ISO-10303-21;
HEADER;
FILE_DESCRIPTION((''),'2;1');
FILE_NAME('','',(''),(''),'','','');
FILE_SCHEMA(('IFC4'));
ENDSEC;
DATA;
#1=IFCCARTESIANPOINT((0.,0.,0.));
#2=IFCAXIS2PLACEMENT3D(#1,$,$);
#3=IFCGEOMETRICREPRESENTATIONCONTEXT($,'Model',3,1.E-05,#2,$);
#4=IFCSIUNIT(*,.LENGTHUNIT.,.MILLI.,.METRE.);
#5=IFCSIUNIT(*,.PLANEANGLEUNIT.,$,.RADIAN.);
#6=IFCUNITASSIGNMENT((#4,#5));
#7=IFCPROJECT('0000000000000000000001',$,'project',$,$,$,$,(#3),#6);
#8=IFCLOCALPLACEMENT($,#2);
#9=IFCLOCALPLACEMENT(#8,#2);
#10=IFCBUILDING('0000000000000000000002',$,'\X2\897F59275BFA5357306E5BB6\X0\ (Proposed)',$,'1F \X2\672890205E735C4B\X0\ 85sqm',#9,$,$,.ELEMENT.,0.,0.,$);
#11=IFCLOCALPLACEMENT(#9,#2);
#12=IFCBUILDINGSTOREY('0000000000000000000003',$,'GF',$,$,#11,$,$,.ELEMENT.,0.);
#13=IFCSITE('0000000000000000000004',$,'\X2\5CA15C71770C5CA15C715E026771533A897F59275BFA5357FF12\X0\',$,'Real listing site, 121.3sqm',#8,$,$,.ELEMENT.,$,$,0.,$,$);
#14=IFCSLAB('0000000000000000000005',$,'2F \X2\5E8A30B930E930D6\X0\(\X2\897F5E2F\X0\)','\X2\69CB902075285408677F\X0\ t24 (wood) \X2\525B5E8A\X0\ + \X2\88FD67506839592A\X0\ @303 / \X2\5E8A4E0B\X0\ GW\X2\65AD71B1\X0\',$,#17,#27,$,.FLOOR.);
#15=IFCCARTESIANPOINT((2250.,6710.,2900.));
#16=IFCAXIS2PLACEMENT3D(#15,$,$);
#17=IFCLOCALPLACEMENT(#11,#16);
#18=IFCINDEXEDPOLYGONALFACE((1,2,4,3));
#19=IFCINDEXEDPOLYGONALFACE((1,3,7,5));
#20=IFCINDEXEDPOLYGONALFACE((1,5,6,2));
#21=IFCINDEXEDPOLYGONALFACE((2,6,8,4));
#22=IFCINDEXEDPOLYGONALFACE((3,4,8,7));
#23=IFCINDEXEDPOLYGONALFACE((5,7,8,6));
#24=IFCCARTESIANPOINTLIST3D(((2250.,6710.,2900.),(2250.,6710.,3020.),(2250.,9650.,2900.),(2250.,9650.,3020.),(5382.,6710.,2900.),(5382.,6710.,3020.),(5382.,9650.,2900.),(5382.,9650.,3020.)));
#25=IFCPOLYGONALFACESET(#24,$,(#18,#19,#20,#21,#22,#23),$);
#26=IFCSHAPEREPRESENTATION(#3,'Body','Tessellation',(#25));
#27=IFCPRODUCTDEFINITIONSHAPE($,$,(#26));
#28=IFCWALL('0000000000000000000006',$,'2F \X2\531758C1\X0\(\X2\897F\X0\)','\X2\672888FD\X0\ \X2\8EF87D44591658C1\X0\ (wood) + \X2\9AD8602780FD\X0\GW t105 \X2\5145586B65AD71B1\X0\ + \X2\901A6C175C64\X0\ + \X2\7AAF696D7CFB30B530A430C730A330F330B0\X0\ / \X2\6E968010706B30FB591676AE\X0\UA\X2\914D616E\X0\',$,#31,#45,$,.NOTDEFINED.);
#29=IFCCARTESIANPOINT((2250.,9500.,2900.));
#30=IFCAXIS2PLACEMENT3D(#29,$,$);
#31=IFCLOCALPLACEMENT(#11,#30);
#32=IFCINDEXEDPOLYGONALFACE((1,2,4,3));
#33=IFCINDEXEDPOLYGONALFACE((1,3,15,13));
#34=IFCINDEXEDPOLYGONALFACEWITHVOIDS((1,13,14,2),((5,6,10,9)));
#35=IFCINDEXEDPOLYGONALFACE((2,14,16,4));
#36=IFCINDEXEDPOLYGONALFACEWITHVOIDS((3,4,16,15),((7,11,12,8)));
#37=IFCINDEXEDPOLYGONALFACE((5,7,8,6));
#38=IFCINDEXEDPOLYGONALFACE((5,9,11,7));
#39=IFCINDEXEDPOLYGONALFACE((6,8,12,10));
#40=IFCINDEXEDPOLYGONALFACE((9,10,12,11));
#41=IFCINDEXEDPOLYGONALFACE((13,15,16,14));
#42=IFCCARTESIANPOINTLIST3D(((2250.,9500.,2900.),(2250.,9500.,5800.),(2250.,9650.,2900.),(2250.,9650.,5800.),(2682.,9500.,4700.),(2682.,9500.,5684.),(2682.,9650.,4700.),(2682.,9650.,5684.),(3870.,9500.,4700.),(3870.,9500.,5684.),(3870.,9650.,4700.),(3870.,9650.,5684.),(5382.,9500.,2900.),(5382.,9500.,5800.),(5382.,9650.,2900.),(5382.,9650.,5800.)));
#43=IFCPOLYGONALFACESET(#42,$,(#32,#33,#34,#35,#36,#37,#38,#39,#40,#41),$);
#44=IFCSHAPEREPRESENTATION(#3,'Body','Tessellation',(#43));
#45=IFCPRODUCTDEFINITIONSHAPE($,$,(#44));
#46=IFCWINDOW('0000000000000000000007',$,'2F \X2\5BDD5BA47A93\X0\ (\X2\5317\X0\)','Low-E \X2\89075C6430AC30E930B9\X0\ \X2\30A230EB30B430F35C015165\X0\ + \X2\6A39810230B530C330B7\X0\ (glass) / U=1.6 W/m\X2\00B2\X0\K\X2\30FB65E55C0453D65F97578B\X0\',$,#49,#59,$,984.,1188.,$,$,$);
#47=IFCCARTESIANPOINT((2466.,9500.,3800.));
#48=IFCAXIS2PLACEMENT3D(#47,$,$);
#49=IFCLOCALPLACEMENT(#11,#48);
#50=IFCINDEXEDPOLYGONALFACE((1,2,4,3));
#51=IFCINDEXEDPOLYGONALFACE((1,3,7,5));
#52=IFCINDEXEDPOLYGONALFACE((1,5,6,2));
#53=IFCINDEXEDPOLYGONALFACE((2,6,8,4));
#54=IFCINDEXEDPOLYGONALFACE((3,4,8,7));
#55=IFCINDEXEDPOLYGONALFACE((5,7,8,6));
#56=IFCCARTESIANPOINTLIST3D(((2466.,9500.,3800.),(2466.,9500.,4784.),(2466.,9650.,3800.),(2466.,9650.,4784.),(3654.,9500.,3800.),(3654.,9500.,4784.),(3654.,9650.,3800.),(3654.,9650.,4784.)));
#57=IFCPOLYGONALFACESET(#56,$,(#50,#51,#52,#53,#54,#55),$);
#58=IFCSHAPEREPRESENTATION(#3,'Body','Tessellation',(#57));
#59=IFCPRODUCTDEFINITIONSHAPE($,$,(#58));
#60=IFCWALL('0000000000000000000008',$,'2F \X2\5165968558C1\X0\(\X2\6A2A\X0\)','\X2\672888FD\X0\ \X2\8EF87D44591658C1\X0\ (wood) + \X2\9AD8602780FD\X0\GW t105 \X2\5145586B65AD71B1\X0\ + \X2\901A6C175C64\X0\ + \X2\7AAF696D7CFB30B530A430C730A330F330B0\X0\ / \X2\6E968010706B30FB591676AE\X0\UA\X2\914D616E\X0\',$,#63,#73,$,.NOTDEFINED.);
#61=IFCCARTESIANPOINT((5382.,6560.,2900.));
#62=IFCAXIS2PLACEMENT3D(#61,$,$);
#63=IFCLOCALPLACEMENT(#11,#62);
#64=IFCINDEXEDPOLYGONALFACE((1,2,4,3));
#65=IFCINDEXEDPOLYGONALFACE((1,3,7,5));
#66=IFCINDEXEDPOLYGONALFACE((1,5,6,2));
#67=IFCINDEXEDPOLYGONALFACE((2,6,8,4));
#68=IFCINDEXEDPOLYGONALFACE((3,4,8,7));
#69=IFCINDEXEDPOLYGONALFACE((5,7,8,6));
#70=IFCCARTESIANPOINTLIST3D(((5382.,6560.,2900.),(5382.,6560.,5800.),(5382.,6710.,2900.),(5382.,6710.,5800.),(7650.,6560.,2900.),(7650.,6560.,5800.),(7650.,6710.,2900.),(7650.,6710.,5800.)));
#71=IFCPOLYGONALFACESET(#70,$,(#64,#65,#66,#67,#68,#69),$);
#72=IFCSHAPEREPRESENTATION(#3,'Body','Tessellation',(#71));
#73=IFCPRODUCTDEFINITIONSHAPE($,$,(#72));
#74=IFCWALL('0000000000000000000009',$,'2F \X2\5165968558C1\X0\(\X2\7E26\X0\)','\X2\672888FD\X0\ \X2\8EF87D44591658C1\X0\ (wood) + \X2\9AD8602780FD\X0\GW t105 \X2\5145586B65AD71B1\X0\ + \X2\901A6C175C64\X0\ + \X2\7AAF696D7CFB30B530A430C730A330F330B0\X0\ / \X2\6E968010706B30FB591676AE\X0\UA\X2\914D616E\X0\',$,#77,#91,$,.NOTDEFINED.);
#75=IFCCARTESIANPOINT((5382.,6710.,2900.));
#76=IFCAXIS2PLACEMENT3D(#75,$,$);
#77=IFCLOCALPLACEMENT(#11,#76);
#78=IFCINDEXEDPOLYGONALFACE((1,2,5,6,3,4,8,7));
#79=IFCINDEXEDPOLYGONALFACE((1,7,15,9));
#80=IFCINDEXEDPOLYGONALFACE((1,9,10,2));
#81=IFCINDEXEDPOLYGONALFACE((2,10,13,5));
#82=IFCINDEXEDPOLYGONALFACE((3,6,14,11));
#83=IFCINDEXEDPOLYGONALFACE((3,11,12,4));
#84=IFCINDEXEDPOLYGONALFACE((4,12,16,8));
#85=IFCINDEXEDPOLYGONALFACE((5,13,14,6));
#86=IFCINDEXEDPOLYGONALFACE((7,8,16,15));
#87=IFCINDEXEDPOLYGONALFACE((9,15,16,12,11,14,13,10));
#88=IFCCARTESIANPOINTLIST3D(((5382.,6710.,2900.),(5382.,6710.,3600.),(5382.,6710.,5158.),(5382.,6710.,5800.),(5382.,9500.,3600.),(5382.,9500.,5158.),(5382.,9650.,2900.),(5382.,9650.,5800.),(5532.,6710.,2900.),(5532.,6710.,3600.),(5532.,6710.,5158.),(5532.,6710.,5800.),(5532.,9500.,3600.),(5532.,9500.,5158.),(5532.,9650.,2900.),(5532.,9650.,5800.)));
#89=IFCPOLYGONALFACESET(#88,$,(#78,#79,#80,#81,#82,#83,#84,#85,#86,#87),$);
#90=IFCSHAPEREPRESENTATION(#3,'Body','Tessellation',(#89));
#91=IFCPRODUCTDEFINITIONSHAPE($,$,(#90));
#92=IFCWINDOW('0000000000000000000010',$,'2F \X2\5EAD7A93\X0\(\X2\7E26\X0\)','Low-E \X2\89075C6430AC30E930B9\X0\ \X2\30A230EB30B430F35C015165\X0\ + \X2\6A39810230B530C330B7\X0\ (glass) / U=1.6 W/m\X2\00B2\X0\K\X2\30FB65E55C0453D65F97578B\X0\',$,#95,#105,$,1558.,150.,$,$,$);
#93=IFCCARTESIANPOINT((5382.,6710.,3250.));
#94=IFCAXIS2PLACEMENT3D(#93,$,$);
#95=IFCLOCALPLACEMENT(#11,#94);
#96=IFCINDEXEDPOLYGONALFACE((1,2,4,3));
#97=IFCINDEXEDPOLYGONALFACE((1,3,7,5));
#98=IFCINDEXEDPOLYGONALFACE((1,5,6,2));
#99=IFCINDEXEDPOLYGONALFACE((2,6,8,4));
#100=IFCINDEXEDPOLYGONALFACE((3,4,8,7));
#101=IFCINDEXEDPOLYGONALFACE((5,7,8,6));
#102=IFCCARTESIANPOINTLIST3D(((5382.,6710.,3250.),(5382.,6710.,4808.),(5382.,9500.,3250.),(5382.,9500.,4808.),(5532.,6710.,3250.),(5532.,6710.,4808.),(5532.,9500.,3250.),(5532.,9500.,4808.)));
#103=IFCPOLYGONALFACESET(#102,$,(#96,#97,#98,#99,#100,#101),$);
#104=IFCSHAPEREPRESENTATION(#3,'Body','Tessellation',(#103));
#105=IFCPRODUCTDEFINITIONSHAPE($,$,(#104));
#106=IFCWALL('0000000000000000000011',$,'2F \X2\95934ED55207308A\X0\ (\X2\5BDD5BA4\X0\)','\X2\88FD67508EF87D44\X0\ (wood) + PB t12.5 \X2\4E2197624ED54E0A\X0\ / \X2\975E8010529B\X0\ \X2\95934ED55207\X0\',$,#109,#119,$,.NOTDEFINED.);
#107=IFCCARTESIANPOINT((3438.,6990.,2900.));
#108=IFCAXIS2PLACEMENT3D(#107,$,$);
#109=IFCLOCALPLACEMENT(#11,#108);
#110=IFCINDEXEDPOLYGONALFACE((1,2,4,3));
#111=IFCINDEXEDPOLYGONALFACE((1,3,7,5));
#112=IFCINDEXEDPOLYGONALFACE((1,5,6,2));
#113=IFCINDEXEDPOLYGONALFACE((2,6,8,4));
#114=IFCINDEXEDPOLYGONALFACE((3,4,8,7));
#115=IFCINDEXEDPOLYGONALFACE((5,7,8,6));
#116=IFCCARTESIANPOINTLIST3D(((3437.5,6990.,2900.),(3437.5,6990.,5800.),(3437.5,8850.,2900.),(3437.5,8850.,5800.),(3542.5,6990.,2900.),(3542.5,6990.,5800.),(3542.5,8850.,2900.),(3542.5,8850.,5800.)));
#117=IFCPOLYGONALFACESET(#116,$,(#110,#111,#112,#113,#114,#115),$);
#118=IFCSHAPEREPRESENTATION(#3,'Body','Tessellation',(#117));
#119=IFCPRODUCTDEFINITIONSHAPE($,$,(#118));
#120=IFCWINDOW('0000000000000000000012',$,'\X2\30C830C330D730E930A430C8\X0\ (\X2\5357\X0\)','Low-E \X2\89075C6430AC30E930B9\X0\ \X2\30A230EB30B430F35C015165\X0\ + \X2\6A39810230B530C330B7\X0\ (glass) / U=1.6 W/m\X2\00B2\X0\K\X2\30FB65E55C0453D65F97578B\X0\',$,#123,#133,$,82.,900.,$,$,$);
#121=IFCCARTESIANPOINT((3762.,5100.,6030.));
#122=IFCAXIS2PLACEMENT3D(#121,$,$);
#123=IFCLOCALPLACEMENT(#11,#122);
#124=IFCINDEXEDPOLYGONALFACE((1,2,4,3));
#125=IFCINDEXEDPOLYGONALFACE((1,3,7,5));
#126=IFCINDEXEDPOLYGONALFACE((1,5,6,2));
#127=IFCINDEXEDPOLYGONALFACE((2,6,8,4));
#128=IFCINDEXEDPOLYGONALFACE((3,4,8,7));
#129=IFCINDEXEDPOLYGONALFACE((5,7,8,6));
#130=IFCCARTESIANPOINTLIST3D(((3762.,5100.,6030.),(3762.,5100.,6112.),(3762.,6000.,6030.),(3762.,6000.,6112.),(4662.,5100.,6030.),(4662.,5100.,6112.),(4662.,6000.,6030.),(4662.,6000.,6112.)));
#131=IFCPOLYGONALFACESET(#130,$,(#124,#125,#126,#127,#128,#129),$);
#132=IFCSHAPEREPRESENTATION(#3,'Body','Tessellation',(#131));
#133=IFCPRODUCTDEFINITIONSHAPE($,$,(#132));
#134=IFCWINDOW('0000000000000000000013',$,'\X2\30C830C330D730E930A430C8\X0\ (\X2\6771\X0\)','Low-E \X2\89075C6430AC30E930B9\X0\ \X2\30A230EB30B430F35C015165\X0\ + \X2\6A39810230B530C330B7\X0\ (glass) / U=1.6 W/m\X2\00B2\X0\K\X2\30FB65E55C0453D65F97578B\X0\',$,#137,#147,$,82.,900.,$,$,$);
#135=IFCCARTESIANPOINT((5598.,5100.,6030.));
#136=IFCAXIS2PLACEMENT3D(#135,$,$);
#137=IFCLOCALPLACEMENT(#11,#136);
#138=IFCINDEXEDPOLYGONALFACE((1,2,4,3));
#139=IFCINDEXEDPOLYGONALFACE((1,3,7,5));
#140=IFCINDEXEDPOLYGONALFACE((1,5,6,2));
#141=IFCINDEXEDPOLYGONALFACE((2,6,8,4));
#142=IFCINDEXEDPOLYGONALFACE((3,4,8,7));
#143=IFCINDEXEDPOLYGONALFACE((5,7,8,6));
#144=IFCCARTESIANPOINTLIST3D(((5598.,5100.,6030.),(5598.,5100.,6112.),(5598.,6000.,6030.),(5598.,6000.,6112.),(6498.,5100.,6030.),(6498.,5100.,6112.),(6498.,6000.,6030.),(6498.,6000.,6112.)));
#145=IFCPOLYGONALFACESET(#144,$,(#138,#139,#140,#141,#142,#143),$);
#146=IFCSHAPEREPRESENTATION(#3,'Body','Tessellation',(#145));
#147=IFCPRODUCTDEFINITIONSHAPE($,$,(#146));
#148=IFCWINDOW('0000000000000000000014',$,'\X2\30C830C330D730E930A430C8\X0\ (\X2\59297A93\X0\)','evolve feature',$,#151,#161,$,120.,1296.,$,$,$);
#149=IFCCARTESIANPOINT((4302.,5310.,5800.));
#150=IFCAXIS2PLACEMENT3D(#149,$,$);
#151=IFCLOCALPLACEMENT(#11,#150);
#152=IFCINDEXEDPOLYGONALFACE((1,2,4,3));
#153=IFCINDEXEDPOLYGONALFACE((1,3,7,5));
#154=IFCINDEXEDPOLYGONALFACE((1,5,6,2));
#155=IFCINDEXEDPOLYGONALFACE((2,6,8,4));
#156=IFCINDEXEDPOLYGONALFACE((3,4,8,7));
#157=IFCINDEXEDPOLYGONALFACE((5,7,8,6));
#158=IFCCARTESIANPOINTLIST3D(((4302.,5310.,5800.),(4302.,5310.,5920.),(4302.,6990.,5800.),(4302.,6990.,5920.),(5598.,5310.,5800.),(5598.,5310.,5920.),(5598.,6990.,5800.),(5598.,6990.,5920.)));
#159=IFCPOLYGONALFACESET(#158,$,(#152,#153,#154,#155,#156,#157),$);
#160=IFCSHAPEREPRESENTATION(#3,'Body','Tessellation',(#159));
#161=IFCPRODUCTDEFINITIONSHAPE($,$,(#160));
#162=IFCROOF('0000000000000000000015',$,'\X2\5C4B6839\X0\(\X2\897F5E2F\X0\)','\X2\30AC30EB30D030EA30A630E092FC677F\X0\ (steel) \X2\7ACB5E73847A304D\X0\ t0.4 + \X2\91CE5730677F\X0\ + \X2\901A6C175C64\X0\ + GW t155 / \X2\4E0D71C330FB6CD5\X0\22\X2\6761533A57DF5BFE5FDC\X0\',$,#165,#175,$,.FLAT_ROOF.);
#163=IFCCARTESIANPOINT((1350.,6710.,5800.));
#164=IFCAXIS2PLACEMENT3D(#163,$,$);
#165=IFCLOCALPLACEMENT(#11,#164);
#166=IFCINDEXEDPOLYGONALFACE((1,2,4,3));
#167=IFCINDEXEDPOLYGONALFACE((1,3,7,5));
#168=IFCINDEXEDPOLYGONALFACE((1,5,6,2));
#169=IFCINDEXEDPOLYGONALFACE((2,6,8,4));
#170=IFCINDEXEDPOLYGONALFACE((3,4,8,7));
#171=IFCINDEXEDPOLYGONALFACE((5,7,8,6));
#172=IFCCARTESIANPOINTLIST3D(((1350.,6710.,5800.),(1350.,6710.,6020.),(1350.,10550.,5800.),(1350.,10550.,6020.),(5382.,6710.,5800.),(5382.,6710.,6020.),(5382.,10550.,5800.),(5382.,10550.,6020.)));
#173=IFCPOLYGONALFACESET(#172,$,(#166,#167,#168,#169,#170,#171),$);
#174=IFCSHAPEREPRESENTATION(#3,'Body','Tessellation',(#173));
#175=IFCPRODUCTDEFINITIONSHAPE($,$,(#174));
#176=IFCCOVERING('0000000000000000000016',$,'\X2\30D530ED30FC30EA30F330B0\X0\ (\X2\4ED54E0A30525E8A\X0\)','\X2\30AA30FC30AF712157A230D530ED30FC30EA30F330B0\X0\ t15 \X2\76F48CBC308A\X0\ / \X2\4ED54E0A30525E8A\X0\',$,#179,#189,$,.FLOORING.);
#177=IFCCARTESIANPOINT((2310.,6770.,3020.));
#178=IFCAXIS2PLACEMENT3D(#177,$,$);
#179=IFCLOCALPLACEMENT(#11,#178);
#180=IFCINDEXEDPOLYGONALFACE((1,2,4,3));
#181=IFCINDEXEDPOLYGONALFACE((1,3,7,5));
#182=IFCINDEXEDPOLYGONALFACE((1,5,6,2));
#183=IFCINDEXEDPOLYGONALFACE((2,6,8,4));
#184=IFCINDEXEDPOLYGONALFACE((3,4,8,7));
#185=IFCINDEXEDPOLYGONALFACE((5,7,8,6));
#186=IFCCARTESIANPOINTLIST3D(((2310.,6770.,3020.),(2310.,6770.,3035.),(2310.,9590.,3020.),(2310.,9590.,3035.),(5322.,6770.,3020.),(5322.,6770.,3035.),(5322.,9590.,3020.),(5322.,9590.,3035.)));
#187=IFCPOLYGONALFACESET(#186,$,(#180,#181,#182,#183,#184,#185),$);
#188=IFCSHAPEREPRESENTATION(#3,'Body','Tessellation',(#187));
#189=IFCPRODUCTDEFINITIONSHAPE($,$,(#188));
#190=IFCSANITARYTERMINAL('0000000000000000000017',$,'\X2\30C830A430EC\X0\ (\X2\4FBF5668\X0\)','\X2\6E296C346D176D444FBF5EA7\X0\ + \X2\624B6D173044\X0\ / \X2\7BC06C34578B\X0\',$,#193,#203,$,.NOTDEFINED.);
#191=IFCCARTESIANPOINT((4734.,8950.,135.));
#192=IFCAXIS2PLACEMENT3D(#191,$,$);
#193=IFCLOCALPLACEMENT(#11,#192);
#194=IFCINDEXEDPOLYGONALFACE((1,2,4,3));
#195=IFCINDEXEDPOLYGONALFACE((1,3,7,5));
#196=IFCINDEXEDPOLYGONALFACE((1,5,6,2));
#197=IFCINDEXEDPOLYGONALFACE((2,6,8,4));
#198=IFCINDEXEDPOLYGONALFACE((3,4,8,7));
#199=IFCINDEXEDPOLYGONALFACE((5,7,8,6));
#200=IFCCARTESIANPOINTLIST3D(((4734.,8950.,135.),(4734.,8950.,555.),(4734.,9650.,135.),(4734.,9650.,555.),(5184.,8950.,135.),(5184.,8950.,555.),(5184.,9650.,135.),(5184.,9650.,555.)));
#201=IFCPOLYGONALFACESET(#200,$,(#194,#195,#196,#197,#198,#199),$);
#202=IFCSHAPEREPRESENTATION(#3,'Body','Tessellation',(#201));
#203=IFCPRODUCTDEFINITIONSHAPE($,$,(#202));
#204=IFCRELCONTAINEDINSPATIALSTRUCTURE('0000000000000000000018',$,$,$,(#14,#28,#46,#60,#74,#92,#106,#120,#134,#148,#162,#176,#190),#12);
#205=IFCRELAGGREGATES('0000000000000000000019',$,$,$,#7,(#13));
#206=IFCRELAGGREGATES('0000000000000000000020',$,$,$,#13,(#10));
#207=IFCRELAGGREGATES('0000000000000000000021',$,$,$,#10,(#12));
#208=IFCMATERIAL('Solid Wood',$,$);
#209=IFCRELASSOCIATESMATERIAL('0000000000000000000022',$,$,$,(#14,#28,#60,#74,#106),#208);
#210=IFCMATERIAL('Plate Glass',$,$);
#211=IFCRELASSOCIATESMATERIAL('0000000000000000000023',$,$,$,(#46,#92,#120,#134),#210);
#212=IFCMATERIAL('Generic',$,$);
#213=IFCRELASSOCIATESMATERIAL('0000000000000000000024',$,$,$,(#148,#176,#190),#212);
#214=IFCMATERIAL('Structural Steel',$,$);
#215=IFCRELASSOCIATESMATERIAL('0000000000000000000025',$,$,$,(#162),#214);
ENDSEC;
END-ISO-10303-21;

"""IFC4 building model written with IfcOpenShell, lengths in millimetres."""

from ifc_helpers import new_model, si_unit, frame, frame_2d, origin, place, context, project, spatial, rectangle, extrude, material, element, fill, save


model = new_model("IFC4")

# Units and contexts
model_context = context("Model", 3, precision=1e-05, world=origin())
ifc_project = project(units=[si_unit("LENGTHUNIT", "METRE", prefix="MILLI"), si_unit("PLANEANGLEUNIT", "RADIAN")], contexts=[model_context])

# Site, building, storey
site_placement = place(None, origin())
site = spatial("IfcSite", under=ifc_project, at=site_placement, Name="岡山県岡山市東区西大寺南２", ObjectType="Real listing site, 121.3sqm", CompositionType="ELEMENT", RefElevation=0.0)
building_placement = place(site_placement, origin())
building = spatial("IfcBuilding", under=site, at=building_placement, Name="西大寺南の家 (Proposed)", ObjectType="1F 木造平屋 85sqm", CompositionType="ELEMENT", ElevationOfRefHeight=0.0, ElevationOfTerrain=0.0)
storey_placement = place(building_placement, origin())
storey = spatial("IfcBuildingStorey", under=building, at=storey_placement, Name="GF", CompositionType="ELEMENT", Elevation=0.0)

# Slab
ifc_material_1 = material(Name="Solid Wood")
slab_placement = place(storey_placement, frame((2250.0, 6710.0, 2900.0)))
element("IfcSlab", 1, at=slab_placement, inside=storey, material=ifc_material_1, Name="2F 床スラブ(西帯)", Description="構造用合板 t24 (wood) 剛床 + 製材根太 @303 / 床下 GW断熱", PredefinedType="FLOOR", context=model_context, shape_type="SweptSolid", body=[
    extrude(rectangle(XDim=3132.0, YDim=2940.0, at=frame_2d((1566.0, 1470.0))), frame((2250.0, 6710.0, 2900.0)), (0.0, 0.0, 1.0), 120.0),
])

# Wall, opening, window
wall_1_placement = place(storey_placement, frame((2250.0, 9500.0, 2900.0)))
wall_1 = element("IfcWall", 2, at=wall_1_placement, inside=storey, material=ifc_material_1, Name="2F 北壁(西)", Description="木製 軸組外壁 (wood) + 高性能GW t105 充填断熱 + 通気層 + 窯業系サイディング / 準耐火・外皮UA配慮", PredefinedType="NOTDEFINED", context=model_context, shape_type="SweptSolid", body=[
    extrude(rectangle(XDim=3132.0, YDim=150.0, at=frame_2d((1566.0, 75.0))), frame((2250.0, 9500.0, 2900.0)), (0.0, 0.0, 1.0), 2900.0),
])
opening_1_placement = place(storey_placement, frame((2466.0, 9500.0, 3800.0)))
opening_1 = element("IfcOpeningElement", 3, at=opening_1_placement, cuts=wall_1, PredefinedType="NOTDEFINED", context=model_context, shape_type="SweptSolid", body=[
    extrude(rectangle(XDim=1188.0, YDim=150.0, at=frame_2d((594.0, 75.0))), frame((2466.0, 9500.0, 3800.0)), (0.0, 0.0, 1.0), 984.0),
])
ifc_material_2 = material(Name="Plate Glass")
window_1_placement = place(storey_placement, frame((2466.0, 9500.0, 3800.0)))
window_1 = element("IfcWindow", 4, at=window_1_placement, inside=storey, material=ifc_material_2, Name="2F 寝室窓 (北)", Description="Low-E 複層ガラス アルゴン封入 + 樹脂サッシ (glass) / U=1.6 W/m²K・日射取得型", OverallHeight=984.0, OverallWidth=1188.0, context=model_context, shape_type="SweptSolid", body=[
    extrude(rectangle(XDim=1188.0, YDim=150.0, at=frame_2d((594.0, 75.0))), frame((2466.0, 9500.0, 3800.0)), (0.0, 0.0, 1.0), 984.0),
])
fill(opening_1, window_1)

# Wall
wall_2_placement = place(storey_placement, frame((5382.0, 6560.0, 2900.0)))
element("IfcWall", 5, at=wall_2_placement, inside=storey, material=ifc_material_1, Name="2F 入隅壁(横)", Description="木製 軸組外壁 (wood) + 高性能GW t105 充填断熱 + 通気層 + 窯業系サイディング / 準耐火・外皮UA配慮", PredefinedType="NOTDEFINED", context=model_context, shape_type="SweptSolid", body=[
    extrude(rectangle(XDim=2268.0, YDim=150.0, at=frame_2d((1134.0, 75.0))), frame((5382.0, 6560.0, 2900.0)), (0.0, 0.0, 1.0), 2900.0),
])

# Wall, opening, window
wall_3_placement = place(storey_placement, frame((5382.0, 6710.0, 2900.0)))
wall_3 = element("IfcWall", 6, at=wall_3_placement, inside=storey, material=ifc_material_1, Name="2F 入隅壁(縦)", Description="木製 軸組外壁 (wood) + 高性能GW t105 充填断熱 + 通気層 + 窯業系サイディング / 準耐火・外皮UA配慮", PredefinedType="NOTDEFINED", context=model_context, shape_type="SweptSolid", body=[
    extrude(rectangle(XDim=150.0, YDim=2940.0, at=frame_2d((75.0, 1470.0))), frame((5382.0, 6710.0, 2900.0)), (0.0, 0.0, 1.0), 2900.0),
])
opening_2_placement = place(storey_placement, frame((5382.0, 6710.0, 3250.0)))
opening_2 = element("IfcOpeningElement", 7, at=opening_2_placement, cuts=wall_3, PredefinedType="NOTDEFINED", context=model_context, shape_type="SweptSolid", body=[
    extrude(rectangle(XDim=150.0, YDim=2790.0, at=frame_2d((75.0, 1395.0))), frame((5382.0, 6710.0, 3250.0)), (0.0, 0.0, 1.0), 1558.0),
])
window_2_placement = place(storey_placement, frame((5382.0, 6710.0, 3250.0)))
window_2 = element("IfcWindow", 8, at=window_2_placement, inside=storey, material=ifc_material_2, Name="2F 庭窓(縦)", Description="Low-E 複層ガラス アルゴン封入 + 樹脂サッシ (glass) / U=1.6 W/m²K・日射取得型", OverallHeight=1558.0, OverallWidth=150.0, context=model_context, shape_type="SweptSolid", body=[
    extrude(rectangle(XDim=150.0, YDim=2790.0, at=frame_2d((75.0, 1395.0))), frame((5382.0, 6710.0, 3250.0)), (0.0, 0.0, 1.0), 1558.0),
])
fill(opening_2, window_2)

# Wall
wall_4_placement = place(storey_placement, frame((3438.0, 6990.0, 2900.0)))
element("IfcWall", 9, at=wall_4_placement, inside=storey, material=ifc_material_1, Name="2F 間仕切り (寝室)", Description="製材軸組 (wood) + PB t12.5 両面仕上 / 非耐力 間仕切", PredefinedType="NOTDEFINED", context=model_context, shape_type="SweptSolid", body=[
    extrude(rectangle(XDim=105.0, YDim=1860.0, at=frame_2d((52.0, 930.0))), frame((3438.0, 6990.0, 2900.0)), (0.0, 0.0, 1.0), 2900.0),
])

# Windows
window_3_placement = place(storey_placement, frame((3762.0, 5100.0, 6030.0)))
element("IfcWindow", 10, at=window_3_placement, inside=storey, material=ifc_material_2, Name="トップライト (南)", Description="Low-E 複層ガラス アルゴン封入 + 樹脂サッシ (glass) / U=1.6 W/m²K・日射取得型", OverallHeight=82.0, OverallWidth=900.0, context=model_context, shape_type="SweptSolid", body=[
    extrude(rectangle(XDim=900.0, YDim=900.0, at=frame_2d((450.0, 450.0))), frame((3762.0, 5100.0, 6030.0)), (0.0, 0.0, 1.0), 82.0),
])
window_4_placement = place(storey_placement, frame((5598.0, 5100.0, 6030.0)))
element("IfcWindow", 11, at=window_4_placement, inside=storey, material=ifc_material_2, Name="トップライト (東)", Description="Low-E 複層ガラス アルゴン封入 + 樹脂サッシ (glass) / U=1.6 W/m²K・日射取得型", OverallHeight=82.0, OverallWidth=900.0, context=model_context, shape_type="SweptSolid", body=[
    extrude(rectangle(XDim=900.0, YDim=900.0, at=frame_2d((450.0, 450.0))), frame((5598.0, 5100.0, 6030.0)), (0.0, 0.0, 1.0), 82.0),
])
ifc_material_3 = material(Name="Generic")
window_5_placement = place(storey_placement, frame((4302.0, 5310.0, 5800.0)))
element("IfcWindow", 12, at=window_5_placement, inside=storey, material=ifc_material_3, Name="トップライト (天窓)", Description="evolve feature", OverallHeight=120.0, OverallWidth=1296.0, context=model_context, shape_type="SweptSolid", body=[
    extrude(rectangle(XDim=1296.0, YDim=1680.0, at=frame_2d((648.0, 840.0))), frame((4302.0, 5310.0, 5800.0)), (0.0, 0.0, 1.0), 120.0),
])

# Roof
ifc_material_4 = material(Name="Structural Steel")
for number, where, name in (
    (13, (1350.0, 6710.0, 5800.0), "屋根(西帯)"),
):
    element("IfcRoof", number, at=place(storey_placement, frame(where)), inside=storey, material=ifc_material_4, Name=name, Description="ガルバリウム鋼板 (steel) 立平葺き t0.4 + 野地板 + 通気層 + GW t155 / 不燃・法22条区域対応", PredefinedType="FLAT_ROOF", context=model_context, shape_type="SweptSolid", body=[
        extrude(rectangle(XDim=4032.0, YDim=3840.0, at=frame_2d((2016.0, 1920.0))), frame((1350.0, 6710.0, 5800.0)), (0.0, 0.0, 1.0), 220.0),
    ])

# Covering
covering_placement = place(storey_placement, frame((2310.0, 6770.0, 3020.0)))
element("IfcCovering", 14, at=covering_placement, inside=storey, material=ifc_material_3, Name="フローリング (仕上げ床)", Description="オーク無垢フローリング t15 直貼り / 仕上げ床", PredefinedType="FLOORING", context=model_context, shape_type="SweptSolid", body=[
    extrude(rectangle(XDim=3012.0, YDim=2820.0, at=frame_2d((1506.0, 1410.0))), frame((2310.0, 6770.0, 3020.0)), (0.0, 0.0, 1.0), 15.0),
])

# Sanitary terminal
sanitary_terminal_placement = place(storey_placement, frame((4734.0, 8950.0, 135.0)))
element("IfcSanitaryTerminal", 15, at=sanitary_terminal_placement, inside=storey, material=ifc_material_3, Name="トイレ (便器)", Description="温水洗浄便座 + 手洗い / 節水型", PredefinedType="NOTDEFINED", context=model_context, shape_type="SweptSolid", body=[
    extrude(rectangle(XDim=450.0, YDim=700.0, at=frame_2d((225.0, 350.0))), frame((4734.0, 8950.0, 135.0)), (0.0, 0.0, 1.0), 420.0),
])

save(model, "model.ifc")
